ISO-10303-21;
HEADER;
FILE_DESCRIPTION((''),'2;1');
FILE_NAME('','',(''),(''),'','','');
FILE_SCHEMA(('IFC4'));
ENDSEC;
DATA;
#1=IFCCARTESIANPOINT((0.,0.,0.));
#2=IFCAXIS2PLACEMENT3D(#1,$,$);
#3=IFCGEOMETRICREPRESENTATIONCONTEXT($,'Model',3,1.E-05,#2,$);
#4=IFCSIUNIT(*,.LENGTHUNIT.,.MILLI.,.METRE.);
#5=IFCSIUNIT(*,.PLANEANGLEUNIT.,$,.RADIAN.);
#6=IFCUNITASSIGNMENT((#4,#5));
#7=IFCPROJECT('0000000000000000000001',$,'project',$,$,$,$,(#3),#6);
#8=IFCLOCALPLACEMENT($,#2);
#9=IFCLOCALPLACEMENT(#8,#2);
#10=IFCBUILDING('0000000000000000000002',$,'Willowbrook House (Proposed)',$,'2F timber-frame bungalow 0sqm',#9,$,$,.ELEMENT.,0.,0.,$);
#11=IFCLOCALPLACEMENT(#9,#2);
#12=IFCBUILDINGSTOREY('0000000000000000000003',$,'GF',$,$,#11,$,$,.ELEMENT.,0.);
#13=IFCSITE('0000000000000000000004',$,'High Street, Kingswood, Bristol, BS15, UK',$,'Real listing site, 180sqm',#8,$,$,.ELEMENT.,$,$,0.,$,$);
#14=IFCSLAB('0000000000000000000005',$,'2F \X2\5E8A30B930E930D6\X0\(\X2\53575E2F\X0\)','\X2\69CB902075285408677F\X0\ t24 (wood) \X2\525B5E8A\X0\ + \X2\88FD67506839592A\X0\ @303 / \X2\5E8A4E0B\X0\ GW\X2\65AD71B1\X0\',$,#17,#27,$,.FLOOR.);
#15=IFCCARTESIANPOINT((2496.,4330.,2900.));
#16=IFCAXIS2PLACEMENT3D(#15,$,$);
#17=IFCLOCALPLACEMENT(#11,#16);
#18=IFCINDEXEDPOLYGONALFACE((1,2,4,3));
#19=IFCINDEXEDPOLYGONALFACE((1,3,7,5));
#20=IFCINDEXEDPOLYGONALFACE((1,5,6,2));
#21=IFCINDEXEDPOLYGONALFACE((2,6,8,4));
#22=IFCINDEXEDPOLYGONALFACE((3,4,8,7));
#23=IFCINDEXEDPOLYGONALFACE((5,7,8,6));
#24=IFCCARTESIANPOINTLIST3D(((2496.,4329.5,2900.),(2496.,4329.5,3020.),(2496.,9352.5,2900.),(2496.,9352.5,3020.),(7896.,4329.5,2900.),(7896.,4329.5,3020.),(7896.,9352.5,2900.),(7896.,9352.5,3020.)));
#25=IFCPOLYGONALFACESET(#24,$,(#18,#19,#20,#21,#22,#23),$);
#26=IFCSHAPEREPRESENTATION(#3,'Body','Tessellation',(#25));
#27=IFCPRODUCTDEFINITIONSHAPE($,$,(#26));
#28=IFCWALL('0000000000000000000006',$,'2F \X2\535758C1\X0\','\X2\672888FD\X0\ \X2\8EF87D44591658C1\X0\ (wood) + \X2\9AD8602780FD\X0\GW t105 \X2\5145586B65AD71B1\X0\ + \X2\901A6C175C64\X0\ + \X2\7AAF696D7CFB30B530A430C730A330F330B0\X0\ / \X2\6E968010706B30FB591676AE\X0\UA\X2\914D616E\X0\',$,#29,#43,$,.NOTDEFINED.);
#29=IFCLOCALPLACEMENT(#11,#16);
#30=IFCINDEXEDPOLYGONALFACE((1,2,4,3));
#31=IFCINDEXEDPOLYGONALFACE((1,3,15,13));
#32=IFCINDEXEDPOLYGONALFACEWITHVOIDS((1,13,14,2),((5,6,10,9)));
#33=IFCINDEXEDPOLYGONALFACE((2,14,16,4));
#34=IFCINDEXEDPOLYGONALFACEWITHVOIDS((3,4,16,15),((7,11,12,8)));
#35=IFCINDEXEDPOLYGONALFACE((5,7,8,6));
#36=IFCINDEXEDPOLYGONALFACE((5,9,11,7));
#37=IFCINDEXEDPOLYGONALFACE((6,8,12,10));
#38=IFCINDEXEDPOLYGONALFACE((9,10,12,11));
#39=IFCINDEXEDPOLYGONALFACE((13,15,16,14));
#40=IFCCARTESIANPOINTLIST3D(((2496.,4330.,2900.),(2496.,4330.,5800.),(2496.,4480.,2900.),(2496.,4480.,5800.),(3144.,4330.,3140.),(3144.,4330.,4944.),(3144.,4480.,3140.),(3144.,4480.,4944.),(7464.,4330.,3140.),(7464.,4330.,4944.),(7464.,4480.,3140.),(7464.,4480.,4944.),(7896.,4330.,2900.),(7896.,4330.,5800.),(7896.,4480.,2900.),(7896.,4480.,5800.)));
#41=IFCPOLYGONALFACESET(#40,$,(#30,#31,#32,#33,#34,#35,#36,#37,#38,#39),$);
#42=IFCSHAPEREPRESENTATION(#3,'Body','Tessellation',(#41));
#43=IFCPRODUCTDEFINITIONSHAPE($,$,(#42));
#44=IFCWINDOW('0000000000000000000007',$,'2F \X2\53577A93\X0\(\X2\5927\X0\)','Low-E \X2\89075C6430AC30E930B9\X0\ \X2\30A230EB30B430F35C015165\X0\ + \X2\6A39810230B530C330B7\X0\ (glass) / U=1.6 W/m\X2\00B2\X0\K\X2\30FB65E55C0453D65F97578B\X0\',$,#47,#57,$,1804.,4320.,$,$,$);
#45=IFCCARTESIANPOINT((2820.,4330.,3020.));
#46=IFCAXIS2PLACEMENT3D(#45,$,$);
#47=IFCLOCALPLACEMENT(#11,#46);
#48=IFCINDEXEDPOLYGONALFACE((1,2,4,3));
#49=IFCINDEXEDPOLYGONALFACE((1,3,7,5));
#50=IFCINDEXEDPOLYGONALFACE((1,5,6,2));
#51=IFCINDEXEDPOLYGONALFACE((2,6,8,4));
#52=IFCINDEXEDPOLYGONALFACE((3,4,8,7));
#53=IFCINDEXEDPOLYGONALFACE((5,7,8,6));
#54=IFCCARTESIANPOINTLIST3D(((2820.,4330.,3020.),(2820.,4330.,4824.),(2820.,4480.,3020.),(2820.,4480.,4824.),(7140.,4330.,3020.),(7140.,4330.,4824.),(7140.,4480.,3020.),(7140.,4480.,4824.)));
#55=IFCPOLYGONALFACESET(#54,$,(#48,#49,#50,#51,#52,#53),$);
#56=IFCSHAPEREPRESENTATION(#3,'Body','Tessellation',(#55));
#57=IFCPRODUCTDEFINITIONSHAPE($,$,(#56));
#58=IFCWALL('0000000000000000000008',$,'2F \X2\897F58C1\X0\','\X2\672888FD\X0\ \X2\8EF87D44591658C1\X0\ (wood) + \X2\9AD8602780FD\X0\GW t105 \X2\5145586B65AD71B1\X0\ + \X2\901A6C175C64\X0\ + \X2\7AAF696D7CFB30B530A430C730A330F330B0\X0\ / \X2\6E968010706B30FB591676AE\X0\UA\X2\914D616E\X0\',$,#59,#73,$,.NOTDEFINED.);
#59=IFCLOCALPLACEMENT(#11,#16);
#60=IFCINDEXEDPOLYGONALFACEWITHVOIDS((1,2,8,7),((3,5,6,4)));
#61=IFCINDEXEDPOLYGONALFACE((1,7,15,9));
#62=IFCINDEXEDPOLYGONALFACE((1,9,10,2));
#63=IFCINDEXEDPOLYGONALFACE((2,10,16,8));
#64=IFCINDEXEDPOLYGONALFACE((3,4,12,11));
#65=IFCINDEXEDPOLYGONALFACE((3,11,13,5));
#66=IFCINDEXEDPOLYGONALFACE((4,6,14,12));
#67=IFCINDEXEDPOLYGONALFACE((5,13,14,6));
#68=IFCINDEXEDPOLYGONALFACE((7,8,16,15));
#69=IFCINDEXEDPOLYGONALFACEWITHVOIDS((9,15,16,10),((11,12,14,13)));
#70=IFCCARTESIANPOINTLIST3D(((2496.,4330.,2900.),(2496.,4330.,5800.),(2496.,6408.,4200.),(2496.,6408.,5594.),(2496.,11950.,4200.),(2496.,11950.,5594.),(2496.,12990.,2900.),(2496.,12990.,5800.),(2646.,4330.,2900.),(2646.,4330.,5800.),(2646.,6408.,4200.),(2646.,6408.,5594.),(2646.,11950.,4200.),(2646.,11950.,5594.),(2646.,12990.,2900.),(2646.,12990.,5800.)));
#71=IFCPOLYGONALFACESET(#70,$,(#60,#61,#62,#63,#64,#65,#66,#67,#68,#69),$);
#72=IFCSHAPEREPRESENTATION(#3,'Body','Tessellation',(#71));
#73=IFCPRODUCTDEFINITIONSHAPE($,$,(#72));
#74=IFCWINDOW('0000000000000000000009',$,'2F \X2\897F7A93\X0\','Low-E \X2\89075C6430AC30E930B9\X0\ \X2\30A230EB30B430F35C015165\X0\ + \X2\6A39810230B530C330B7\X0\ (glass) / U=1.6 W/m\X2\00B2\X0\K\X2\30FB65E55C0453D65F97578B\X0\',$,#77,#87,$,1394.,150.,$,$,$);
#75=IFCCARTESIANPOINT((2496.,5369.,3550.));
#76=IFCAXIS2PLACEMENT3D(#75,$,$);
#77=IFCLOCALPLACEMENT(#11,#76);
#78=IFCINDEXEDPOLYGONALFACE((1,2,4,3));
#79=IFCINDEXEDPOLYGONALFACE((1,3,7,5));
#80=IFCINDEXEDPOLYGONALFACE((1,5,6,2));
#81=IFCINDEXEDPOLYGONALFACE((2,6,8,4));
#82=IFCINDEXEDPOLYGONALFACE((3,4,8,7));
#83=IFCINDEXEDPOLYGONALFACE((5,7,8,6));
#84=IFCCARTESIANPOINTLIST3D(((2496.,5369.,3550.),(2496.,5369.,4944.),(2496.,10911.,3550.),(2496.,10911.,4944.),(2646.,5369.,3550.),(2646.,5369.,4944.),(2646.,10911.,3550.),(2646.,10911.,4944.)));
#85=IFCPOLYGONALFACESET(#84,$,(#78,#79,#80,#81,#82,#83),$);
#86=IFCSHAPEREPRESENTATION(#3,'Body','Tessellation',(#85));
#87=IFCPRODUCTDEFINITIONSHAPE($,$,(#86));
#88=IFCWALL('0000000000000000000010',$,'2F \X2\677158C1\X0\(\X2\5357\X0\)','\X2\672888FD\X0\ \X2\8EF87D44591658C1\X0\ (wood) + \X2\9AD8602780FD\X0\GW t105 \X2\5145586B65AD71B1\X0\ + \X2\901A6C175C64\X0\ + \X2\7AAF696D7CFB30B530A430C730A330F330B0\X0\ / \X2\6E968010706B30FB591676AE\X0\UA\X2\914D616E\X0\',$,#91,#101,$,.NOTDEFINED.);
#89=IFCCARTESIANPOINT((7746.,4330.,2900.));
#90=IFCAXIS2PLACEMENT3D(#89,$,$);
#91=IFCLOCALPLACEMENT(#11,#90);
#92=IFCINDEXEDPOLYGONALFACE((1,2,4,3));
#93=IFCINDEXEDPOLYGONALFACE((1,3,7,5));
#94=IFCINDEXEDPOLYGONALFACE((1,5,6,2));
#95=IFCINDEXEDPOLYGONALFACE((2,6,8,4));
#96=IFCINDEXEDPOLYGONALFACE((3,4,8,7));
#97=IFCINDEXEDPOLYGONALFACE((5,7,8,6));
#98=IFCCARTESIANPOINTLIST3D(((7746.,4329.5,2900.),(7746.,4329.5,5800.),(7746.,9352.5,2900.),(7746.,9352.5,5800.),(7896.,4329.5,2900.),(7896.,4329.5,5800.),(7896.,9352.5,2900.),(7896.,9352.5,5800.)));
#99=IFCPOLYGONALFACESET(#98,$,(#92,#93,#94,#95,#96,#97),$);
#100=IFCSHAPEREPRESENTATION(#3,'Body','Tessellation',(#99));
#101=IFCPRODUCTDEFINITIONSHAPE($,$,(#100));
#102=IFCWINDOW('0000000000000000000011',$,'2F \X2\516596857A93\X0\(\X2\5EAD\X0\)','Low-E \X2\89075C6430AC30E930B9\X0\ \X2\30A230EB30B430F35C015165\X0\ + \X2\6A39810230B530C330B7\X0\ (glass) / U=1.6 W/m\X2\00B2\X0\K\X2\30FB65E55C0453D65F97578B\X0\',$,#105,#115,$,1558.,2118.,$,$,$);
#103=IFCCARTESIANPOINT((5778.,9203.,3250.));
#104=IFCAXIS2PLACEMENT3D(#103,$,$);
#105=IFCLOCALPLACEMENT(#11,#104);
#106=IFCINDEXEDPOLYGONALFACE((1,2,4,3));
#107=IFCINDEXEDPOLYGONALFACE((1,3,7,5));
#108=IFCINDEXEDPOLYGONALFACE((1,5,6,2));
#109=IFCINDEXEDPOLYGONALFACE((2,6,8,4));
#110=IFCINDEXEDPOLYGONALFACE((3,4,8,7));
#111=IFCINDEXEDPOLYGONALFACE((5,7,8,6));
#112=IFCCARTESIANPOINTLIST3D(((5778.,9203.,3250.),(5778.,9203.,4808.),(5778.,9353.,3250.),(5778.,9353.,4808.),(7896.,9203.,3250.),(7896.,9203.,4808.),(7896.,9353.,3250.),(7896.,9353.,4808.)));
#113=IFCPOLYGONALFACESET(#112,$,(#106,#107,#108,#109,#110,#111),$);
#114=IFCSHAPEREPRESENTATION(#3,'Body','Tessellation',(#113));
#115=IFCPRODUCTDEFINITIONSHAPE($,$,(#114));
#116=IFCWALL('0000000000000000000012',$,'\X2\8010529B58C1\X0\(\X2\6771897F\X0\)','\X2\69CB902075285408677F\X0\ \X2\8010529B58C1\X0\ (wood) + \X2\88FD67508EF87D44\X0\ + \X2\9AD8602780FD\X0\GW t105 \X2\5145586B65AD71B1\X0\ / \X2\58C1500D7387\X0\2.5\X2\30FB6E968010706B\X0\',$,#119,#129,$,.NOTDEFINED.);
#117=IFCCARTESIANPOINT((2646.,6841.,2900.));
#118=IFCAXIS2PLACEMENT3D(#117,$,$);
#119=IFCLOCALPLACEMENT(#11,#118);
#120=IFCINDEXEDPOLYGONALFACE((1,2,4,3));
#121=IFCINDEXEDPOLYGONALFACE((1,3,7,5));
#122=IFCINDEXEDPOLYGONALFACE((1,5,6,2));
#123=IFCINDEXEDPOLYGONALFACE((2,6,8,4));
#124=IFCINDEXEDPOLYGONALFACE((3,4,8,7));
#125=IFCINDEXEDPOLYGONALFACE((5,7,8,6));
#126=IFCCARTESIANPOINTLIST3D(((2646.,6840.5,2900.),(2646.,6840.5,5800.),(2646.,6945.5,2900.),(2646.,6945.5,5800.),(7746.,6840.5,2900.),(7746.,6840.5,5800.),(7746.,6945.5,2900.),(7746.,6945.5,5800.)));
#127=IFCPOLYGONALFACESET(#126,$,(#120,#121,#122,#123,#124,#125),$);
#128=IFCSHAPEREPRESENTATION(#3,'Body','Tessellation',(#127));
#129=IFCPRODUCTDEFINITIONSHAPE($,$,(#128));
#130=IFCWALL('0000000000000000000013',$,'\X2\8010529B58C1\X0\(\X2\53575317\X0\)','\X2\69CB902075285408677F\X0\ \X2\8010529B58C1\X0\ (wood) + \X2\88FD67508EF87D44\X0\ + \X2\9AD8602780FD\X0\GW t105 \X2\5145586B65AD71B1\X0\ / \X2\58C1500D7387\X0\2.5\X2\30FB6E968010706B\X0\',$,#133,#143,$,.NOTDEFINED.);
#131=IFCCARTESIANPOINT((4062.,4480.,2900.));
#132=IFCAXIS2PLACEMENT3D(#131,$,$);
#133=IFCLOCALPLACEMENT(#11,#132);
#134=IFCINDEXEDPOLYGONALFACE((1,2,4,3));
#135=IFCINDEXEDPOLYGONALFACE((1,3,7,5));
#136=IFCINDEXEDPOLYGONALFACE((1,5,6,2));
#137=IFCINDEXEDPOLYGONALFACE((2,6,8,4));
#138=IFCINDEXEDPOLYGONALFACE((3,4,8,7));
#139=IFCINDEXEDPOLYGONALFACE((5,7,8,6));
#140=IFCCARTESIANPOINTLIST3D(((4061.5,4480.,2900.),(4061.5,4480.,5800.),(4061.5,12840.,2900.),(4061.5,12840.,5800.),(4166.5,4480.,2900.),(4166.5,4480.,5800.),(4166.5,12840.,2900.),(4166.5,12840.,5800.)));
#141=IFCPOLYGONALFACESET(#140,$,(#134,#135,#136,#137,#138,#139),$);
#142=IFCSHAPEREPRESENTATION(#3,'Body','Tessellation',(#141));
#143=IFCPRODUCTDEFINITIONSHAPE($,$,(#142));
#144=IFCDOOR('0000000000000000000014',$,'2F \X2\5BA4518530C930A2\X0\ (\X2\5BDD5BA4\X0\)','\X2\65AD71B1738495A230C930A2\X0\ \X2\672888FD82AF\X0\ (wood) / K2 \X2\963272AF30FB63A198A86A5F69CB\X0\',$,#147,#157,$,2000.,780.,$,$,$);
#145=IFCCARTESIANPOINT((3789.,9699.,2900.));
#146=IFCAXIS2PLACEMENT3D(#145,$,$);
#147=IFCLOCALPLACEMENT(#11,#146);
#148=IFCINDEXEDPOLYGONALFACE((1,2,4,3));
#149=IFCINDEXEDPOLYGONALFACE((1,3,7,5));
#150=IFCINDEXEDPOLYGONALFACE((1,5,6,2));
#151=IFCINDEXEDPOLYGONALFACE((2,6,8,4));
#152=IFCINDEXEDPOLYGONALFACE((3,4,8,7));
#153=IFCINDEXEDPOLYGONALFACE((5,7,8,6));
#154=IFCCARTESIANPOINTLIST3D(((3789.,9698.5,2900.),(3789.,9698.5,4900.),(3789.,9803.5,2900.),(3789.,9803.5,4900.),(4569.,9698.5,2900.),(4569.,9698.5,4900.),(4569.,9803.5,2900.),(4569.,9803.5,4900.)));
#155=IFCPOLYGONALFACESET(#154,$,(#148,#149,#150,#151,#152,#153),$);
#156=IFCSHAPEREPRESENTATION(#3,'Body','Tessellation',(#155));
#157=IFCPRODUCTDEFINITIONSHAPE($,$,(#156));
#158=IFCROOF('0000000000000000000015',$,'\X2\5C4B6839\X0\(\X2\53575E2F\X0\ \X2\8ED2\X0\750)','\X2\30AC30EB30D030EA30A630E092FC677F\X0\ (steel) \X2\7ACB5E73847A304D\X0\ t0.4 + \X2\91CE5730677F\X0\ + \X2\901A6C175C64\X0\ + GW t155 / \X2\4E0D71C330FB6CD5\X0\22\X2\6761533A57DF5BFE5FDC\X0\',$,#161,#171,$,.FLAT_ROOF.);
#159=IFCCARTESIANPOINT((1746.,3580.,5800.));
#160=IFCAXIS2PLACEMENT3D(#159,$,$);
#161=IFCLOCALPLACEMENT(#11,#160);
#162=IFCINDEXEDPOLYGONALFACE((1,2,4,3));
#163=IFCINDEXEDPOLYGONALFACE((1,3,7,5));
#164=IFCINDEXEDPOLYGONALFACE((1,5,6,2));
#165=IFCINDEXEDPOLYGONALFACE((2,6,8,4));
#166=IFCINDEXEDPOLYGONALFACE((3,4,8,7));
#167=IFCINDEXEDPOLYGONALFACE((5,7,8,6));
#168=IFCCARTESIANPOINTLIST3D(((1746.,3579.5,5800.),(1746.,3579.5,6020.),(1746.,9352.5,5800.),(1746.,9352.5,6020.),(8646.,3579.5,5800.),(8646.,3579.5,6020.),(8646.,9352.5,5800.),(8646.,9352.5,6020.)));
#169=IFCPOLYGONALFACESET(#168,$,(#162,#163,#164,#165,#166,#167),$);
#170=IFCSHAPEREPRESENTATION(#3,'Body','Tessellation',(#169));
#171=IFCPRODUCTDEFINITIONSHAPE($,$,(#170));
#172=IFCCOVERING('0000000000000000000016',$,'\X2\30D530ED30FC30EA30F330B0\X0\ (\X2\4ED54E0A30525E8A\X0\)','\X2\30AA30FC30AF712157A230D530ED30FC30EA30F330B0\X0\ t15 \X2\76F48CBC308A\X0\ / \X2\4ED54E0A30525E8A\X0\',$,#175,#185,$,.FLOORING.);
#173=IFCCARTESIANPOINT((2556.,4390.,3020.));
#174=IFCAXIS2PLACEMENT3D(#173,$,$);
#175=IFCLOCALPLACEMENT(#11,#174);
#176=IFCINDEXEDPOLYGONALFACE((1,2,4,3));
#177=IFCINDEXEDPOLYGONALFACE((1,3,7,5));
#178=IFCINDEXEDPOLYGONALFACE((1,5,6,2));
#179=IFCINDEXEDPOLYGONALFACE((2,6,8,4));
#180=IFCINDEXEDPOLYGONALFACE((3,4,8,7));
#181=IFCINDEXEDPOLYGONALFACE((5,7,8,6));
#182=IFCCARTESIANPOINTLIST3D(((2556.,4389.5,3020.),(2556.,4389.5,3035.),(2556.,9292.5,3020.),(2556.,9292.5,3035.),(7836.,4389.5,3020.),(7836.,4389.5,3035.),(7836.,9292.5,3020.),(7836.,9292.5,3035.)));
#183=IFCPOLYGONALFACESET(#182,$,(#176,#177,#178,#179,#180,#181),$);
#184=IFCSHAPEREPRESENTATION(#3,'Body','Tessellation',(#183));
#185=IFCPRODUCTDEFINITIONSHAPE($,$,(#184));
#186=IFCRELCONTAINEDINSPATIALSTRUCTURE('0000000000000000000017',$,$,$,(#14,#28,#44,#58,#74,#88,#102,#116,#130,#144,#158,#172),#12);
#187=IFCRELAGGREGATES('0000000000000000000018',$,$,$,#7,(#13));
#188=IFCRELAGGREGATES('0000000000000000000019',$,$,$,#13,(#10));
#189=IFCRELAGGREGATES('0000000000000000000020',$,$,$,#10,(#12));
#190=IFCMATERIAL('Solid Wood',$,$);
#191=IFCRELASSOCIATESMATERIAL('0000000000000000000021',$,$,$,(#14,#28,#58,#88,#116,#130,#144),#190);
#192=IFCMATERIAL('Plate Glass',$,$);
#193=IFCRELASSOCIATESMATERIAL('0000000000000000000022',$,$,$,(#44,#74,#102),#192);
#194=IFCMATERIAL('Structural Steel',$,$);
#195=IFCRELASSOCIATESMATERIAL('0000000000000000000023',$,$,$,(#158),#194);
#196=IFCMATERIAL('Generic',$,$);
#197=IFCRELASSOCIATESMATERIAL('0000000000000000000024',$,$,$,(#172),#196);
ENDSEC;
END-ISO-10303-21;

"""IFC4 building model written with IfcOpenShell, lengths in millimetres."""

from ifc_helpers import new_model, si_unit, frame, frame_2d, origin, place, context, project, spatial, rectangle, extrude, material, element, fill, save


model = new_model("IFC4")

# Units and contexts
model_context = context("Model", 3, precision=1e-05, world=origin())
ifc_project = project(units=[si_unit("LENGTHUNIT", "METRE", prefix="MILLI"), si_unit("PLANEANGLEUNIT", "RADIAN")], contexts=[model_context])

# Site, building, storey
site_placement = place(None, origin())
site = spatial("IfcSite", under=ifc_project, at=site_placement, Name="High Street, Kingswood, Bristol, BS15, UK", ObjectType="Real listing site, 180sqm", CompositionType="ELEMENT", RefElevation=0.0)
building_placement = place(site_placement, origin())
building = spatial("IfcBuilding", under=site, at=building_placement, Name="Willowbrook House (Proposed)", ObjectType="2F timber-frame bungalow 0sqm", CompositionType="ELEMENT", ElevationOfRefHeight=0.0, ElevationOfTerrain=0.0)
storey_placement = place(building_placement, origin())
storey = spatial("IfcBuildingStorey", under=building, at=storey_placement, Name="GF", CompositionType="ELEMENT", Elevation=0.0)

# Slab
ifc_material_1 = material(Name="Solid Wood")
slab_placement = place(storey_placement, frame((2496.0, 4330.0, 2900.0)))
element("IfcSlab", 1, at=slab_placement, inside=storey, material=ifc_material_1, Name="2F 床スラブ(南帯)", Description="構造用合板 t24 (wood) 剛床 + 製材根太 @303 / 床下 GW断熱", PredefinedType="FLOOR", context=model_context, shape_type="SweptSolid", body=[
    extrude(rectangle(XDim=5400.0, YDim=5023.0, at=frame_2d((2700.0, 2511.0))), frame((2496.0, 4330.0, 2900.0)), (0.0, 0.0, 1.0), 120.0),
])

# Walls, openings, windows
wall_1_placement = place(storey_placement, frame((2496.0, 4330.0, 2900.0)))
wall_1 = element("IfcWall", 2, at=wall_1_placement, inside=storey, material=ifc_material_1, Name="2F 南壁", Description="木製 軸組外壁 (wood) + 高性能GW t105 充填断熱 + 通気層 + 窯業系サイディング / 準耐火・外皮UA配慮", PredefinedType="NOTDEFINED", context=model_context, shape_type="SweptSolid", body=[
    extrude(rectangle(XDim=5400.0, YDim=150.0, at=frame_2d((2700.0, 75.0))), frame((2496.0, 4330.0, 2900.0)), (0.0, 0.0, 1.0), 2900.0),
])
opening_1_placement = place(storey_placement, frame((2820.0, 4330.0, 3020.0)))
opening_1 = element("IfcOpeningElement", 3, at=opening_1_placement, cuts=wall_1, PredefinedType="NOTDEFINED", context=model_context, shape_type="SweptSolid", body=[
    extrude(rectangle(XDim=4320.0, YDim=150.0, at=frame_2d((2160.0, 75.0))), frame((2820.0, 4330.0, 3020.0)), (0.0, 0.0, 1.0), 1804.0),
])
ifc_material_2 = material(Name="Plate Glass")
window_1_placement = place(storey_placement, frame((2820.0, 4330.0, 3020.0)))
window_1 = element("IfcWindow", 4, at=window_1_placement, inside=storey, material=ifc_material_2, Name="2F 南窓(大)", Description="Low-E 複層ガラス アルゴン封入 + 樹脂サッシ (glass) / U=1.6 W/m²K・日射取得型", OverallHeight=1804.0, OverallWidth=4320.0, context=model_context, shape_type="SweptSolid", body=[
    extrude(rectangle(XDim=4320.0, YDim=150.0, at=frame_2d((2160.0, 75.0))), frame((2820.0, 4330.0, 3020.0)), (0.0, 0.0, 1.0), 1804.0),
])
fill(opening_1, window_1)
wall_2_placement = place(storey_placement, frame((2496.0, 4330.0, 2900.0)))
wall_2 = element("IfcWall", 5, at=wall_2_placement, inside=storey, material=ifc_material_1, Name="2F 西壁", Description="木製 軸組外壁 (wood) + 高性能GW t105 充填断熱 + 通気層 + 窯業系サイディング / 準耐火・外皮UA配慮", PredefinedType="NOTDEFINED", context=model_context, shape_type="SweptSolid", body=[
    extrude(rectangle(XDim=150.0, YDim=8660.0, at=frame_2d((75.0, 4330.0))), frame((2496.0, 4330.0, 2900.0)), (0.0, 0.0, 1.0), 2900.0),
])
opening_2_placement = place(storey_placement, frame((2496.0, 5369.0, 3550.0)))
opening_2 = element("IfcOpeningElement", 6, at=opening_2_placement, cuts=wall_2, PredefinedType="NOTDEFINED", context=model_context, shape_type="SweptSolid", body=[
    extrude(rectangle(XDim=150.0, YDim=5542.0, at=frame_2d((75.0, 2771.0))), frame((2496.0, 5369.0, 3550.0)), (0.0, 0.0, 1.0), 1394.0),
])
window_2_placement = place(storey_placement, frame((2496.0, 5369.0, 3550.0)))
window_2 = element("IfcWindow", 7, at=window_2_placement, inside=storey, material=ifc_material_2, Name="2F 西窓", Description="Low-E 複層ガラス アルゴン封入 + 樹脂サッシ (glass) / U=1.6 W/m²K・日射取得型", OverallHeight=1394.0, OverallWidth=150.0, context=model_context, shape_type="SweptSolid", body=[
    extrude(rectangle(XDim=150.0, YDim=5542.0, at=frame_2d((75.0, 2771.0))), frame((2496.0, 5369.0, 3550.0)), (0.0, 0.0, 1.0), 1394.0),
])
fill(opening_2, window_2)
wall_3_placement = place(storey_placement, frame((7746.0, 4330.0, 2900.0)))
wall_3 = element("IfcWall", 8, at=wall_3_placement, inside=storey, material=ifc_material_1, Name="2F 東壁(南)", Description="木製 軸組外壁 (wood) + 高性能GW t105 充填断熱 + 通気層 + 窯業系サイディング / 準耐火・外皮UA配慮", PredefinedType="NOTDEFINED", context=model_context, shape_type="SweptSolid", body=[
    extrude(rectangle(XDim=150.0, YDim=5023.0, at=frame_2d((75.0, 2511.0))), frame((7746.0, 4330.0, 2900.0)), (0.0, 0.0, 1.0), 2900.0),
])
opening_3_placement = place(storey_placement, frame((5778.0, 9203.0, 3250.0)))
opening_3 = element("IfcOpeningElement", 9, at=opening_3_placement, cuts=wall_3, PredefinedType="NOTDEFINED", context=model_context, shape_type="SweptSolid", body=[
    extrude(rectangle(XDim=2118.0, YDim=150.0, at=frame_2d((1059.0, 75.0))), frame((5778.0, 9203.0, 3250.0)), (0.0, 0.0, 1.0), 1558.0),
])
window_3_placement = place(storey_placement, frame((5778.0, 9203.0, 3250.0)))
window_3 = element("IfcWindow", 10, at=window_3_placement, inside=storey, material=ifc_material_2, Name="2F 入隅窓(庭)", Description="Low-E 複層ガラス アルゴン封入 + 樹脂サッシ (glass) / U=1.6 W/m²K・日射取得型", OverallHeight=1558.0, OverallWidth=2118.0, context=model_context, shape_type="SweptSolid", body=[
    extrude(rectangle(XDim=2118.0, YDim=150.0, at=frame_2d((1059.0, 75.0))), frame((5778.0, 9203.0, 3250.0)), (0.0, 0.0, 1.0), 1558.0),
])
fill(opening_3, window_3)

# Wall
wall_4_placement = place(storey_placement, frame((2646.0, 6841.0, 2900.0)))
element("IfcWall", 11, at=wall_4_placement, inside=storey, material=ifc_material_1, Name="耐力壁(東西)", Description="構造用合板 耐力壁 (wood) + 製材軸組 + 高性能GW t105 充填断熱 / 壁倍率2.5・準耐火", PredefinedType="NOTDEFINED", context=model_context, shape_type="SweptSolid", body=[
    extrude(rectangle(XDim=5100.0, YDim=105.0, at=frame_2d((2550.0, 52.0))), frame((2646.0, 6841.0, 2900.0)), (0.0, 0.0, 1.0), 2900.0),
])

# Wall, opening, door
wall_5_placement = place(storey_placement, frame((4062.0, 4480.0, 2900.0)))
wall_5 = element("IfcWall", 12, at=wall_5_placement, inside=storey, material=ifc_material_1, Name="耐力壁(南北)", Description="構造用合板 耐力壁 (wood) + 製材軸組 + 高性能GW t105 充填断熱 / 壁倍率2.5・準耐火", PredefinedType="NOTDEFINED", context=model_context, shape_type="SweptSolid", body=[
    extrude(rectangle(XDim=105.0, YDim=8360.0, at=frame_2d((52.0, 4180.0))), frame((4062.0, 4480.0, 2900.0)), (0.0, 0.0, 1.0), 2900.0),
])
opening_4_placement = place(storey_placement, frame((3789.0, 9699.0, 2900.0)))
opening_4 = element("IfcOpeningElement", 13, at=opening_4_placement, cuts=wall_5, PredefinedType="NOTDEFINED", context=model_context, shape_type="SweptSolid", body=[
    extrude(rectangle(XDim=780.0, YDim=105.0, at=frame_2d((390.0, 52.0))), frame((3789.0, 9699.0, 2900.0)), (0.0, 0.0, 1.0), 2000.0),
])
door_placement = place(storey_placement, frame((3789.0, 9699.0, 2900.0)))
door = element("IfcDoor", 14, at=door_placement, inside=storey, material=ifc_material_1, Name="2F 室内ドア (寝室)", Description="断熱玄関ドア 木製芯 (wood) / K2 防犯・採風機構", OverallHeight=2000.0, OverallWidth=780.0, context=model_context, shape_type="SweptSolid", body=[
    extrude(rectangle(XDim=780.0, YDim=105.0, at=frame_2d((390.0, 52.0))), frame((3789.0, 9699.0, 2900.0)), (0.0, 0.0, 1.0), 2000.0),
])
fill(opening_4, door)

# Roof
ifc_material_3 = material(Name="Structural Steel")
for number, where, name in (
    (15, (1746.0, 3580.0, 5800.0), "屋根(南帯 軒750)"),
):
    element("IfcRoof", number, at=place(storey_placement, frame(where)), inside=storey, material=ifc_material_3, Name=name, Description="ガルバリウム鋼板 (steel) 立平葺き t0.4 + 野地板 + 通気層 + GW t155 / 不燃・法22条区域対応", PredefinedType="FLAT_ROOF", context=model_context, shape_type="SweptSolid", body=[
        extrude(rectangle(XDim=6900.0, YDim=5773.0, at=frame_2d((3450.0, 2886.0))), frame((1746.0, 3580.0, 5800.0)), (0.0, 0.0, 1.0), 220.0),
    ])

# Covering
ifc_material_4 = material(Name="Generic")
covering_placement = place(storey_placement, frame((2556.0, 4390.0, 3020.0)))
element("IfcCovering", 16, at=covering_placement, inside=storey, material=ifc_material_4, Name="フローリング (仕上げ床)", Description="オーク無垢フローリング t15 直貼り / 仕上げ床", PredefinedType="FLOORING", context=model_context, shape_type="SweptSolid", body=[
    extrude(rectangle(XDim=5280.0, YDim=4903.0, at=frame_2d((2640.0, 2451.0))), frame((2556.0, 4390.0, 3020.0)), (0.0, 0.0, 1.0), 15.0),
])

save(model, "model.ifc")
